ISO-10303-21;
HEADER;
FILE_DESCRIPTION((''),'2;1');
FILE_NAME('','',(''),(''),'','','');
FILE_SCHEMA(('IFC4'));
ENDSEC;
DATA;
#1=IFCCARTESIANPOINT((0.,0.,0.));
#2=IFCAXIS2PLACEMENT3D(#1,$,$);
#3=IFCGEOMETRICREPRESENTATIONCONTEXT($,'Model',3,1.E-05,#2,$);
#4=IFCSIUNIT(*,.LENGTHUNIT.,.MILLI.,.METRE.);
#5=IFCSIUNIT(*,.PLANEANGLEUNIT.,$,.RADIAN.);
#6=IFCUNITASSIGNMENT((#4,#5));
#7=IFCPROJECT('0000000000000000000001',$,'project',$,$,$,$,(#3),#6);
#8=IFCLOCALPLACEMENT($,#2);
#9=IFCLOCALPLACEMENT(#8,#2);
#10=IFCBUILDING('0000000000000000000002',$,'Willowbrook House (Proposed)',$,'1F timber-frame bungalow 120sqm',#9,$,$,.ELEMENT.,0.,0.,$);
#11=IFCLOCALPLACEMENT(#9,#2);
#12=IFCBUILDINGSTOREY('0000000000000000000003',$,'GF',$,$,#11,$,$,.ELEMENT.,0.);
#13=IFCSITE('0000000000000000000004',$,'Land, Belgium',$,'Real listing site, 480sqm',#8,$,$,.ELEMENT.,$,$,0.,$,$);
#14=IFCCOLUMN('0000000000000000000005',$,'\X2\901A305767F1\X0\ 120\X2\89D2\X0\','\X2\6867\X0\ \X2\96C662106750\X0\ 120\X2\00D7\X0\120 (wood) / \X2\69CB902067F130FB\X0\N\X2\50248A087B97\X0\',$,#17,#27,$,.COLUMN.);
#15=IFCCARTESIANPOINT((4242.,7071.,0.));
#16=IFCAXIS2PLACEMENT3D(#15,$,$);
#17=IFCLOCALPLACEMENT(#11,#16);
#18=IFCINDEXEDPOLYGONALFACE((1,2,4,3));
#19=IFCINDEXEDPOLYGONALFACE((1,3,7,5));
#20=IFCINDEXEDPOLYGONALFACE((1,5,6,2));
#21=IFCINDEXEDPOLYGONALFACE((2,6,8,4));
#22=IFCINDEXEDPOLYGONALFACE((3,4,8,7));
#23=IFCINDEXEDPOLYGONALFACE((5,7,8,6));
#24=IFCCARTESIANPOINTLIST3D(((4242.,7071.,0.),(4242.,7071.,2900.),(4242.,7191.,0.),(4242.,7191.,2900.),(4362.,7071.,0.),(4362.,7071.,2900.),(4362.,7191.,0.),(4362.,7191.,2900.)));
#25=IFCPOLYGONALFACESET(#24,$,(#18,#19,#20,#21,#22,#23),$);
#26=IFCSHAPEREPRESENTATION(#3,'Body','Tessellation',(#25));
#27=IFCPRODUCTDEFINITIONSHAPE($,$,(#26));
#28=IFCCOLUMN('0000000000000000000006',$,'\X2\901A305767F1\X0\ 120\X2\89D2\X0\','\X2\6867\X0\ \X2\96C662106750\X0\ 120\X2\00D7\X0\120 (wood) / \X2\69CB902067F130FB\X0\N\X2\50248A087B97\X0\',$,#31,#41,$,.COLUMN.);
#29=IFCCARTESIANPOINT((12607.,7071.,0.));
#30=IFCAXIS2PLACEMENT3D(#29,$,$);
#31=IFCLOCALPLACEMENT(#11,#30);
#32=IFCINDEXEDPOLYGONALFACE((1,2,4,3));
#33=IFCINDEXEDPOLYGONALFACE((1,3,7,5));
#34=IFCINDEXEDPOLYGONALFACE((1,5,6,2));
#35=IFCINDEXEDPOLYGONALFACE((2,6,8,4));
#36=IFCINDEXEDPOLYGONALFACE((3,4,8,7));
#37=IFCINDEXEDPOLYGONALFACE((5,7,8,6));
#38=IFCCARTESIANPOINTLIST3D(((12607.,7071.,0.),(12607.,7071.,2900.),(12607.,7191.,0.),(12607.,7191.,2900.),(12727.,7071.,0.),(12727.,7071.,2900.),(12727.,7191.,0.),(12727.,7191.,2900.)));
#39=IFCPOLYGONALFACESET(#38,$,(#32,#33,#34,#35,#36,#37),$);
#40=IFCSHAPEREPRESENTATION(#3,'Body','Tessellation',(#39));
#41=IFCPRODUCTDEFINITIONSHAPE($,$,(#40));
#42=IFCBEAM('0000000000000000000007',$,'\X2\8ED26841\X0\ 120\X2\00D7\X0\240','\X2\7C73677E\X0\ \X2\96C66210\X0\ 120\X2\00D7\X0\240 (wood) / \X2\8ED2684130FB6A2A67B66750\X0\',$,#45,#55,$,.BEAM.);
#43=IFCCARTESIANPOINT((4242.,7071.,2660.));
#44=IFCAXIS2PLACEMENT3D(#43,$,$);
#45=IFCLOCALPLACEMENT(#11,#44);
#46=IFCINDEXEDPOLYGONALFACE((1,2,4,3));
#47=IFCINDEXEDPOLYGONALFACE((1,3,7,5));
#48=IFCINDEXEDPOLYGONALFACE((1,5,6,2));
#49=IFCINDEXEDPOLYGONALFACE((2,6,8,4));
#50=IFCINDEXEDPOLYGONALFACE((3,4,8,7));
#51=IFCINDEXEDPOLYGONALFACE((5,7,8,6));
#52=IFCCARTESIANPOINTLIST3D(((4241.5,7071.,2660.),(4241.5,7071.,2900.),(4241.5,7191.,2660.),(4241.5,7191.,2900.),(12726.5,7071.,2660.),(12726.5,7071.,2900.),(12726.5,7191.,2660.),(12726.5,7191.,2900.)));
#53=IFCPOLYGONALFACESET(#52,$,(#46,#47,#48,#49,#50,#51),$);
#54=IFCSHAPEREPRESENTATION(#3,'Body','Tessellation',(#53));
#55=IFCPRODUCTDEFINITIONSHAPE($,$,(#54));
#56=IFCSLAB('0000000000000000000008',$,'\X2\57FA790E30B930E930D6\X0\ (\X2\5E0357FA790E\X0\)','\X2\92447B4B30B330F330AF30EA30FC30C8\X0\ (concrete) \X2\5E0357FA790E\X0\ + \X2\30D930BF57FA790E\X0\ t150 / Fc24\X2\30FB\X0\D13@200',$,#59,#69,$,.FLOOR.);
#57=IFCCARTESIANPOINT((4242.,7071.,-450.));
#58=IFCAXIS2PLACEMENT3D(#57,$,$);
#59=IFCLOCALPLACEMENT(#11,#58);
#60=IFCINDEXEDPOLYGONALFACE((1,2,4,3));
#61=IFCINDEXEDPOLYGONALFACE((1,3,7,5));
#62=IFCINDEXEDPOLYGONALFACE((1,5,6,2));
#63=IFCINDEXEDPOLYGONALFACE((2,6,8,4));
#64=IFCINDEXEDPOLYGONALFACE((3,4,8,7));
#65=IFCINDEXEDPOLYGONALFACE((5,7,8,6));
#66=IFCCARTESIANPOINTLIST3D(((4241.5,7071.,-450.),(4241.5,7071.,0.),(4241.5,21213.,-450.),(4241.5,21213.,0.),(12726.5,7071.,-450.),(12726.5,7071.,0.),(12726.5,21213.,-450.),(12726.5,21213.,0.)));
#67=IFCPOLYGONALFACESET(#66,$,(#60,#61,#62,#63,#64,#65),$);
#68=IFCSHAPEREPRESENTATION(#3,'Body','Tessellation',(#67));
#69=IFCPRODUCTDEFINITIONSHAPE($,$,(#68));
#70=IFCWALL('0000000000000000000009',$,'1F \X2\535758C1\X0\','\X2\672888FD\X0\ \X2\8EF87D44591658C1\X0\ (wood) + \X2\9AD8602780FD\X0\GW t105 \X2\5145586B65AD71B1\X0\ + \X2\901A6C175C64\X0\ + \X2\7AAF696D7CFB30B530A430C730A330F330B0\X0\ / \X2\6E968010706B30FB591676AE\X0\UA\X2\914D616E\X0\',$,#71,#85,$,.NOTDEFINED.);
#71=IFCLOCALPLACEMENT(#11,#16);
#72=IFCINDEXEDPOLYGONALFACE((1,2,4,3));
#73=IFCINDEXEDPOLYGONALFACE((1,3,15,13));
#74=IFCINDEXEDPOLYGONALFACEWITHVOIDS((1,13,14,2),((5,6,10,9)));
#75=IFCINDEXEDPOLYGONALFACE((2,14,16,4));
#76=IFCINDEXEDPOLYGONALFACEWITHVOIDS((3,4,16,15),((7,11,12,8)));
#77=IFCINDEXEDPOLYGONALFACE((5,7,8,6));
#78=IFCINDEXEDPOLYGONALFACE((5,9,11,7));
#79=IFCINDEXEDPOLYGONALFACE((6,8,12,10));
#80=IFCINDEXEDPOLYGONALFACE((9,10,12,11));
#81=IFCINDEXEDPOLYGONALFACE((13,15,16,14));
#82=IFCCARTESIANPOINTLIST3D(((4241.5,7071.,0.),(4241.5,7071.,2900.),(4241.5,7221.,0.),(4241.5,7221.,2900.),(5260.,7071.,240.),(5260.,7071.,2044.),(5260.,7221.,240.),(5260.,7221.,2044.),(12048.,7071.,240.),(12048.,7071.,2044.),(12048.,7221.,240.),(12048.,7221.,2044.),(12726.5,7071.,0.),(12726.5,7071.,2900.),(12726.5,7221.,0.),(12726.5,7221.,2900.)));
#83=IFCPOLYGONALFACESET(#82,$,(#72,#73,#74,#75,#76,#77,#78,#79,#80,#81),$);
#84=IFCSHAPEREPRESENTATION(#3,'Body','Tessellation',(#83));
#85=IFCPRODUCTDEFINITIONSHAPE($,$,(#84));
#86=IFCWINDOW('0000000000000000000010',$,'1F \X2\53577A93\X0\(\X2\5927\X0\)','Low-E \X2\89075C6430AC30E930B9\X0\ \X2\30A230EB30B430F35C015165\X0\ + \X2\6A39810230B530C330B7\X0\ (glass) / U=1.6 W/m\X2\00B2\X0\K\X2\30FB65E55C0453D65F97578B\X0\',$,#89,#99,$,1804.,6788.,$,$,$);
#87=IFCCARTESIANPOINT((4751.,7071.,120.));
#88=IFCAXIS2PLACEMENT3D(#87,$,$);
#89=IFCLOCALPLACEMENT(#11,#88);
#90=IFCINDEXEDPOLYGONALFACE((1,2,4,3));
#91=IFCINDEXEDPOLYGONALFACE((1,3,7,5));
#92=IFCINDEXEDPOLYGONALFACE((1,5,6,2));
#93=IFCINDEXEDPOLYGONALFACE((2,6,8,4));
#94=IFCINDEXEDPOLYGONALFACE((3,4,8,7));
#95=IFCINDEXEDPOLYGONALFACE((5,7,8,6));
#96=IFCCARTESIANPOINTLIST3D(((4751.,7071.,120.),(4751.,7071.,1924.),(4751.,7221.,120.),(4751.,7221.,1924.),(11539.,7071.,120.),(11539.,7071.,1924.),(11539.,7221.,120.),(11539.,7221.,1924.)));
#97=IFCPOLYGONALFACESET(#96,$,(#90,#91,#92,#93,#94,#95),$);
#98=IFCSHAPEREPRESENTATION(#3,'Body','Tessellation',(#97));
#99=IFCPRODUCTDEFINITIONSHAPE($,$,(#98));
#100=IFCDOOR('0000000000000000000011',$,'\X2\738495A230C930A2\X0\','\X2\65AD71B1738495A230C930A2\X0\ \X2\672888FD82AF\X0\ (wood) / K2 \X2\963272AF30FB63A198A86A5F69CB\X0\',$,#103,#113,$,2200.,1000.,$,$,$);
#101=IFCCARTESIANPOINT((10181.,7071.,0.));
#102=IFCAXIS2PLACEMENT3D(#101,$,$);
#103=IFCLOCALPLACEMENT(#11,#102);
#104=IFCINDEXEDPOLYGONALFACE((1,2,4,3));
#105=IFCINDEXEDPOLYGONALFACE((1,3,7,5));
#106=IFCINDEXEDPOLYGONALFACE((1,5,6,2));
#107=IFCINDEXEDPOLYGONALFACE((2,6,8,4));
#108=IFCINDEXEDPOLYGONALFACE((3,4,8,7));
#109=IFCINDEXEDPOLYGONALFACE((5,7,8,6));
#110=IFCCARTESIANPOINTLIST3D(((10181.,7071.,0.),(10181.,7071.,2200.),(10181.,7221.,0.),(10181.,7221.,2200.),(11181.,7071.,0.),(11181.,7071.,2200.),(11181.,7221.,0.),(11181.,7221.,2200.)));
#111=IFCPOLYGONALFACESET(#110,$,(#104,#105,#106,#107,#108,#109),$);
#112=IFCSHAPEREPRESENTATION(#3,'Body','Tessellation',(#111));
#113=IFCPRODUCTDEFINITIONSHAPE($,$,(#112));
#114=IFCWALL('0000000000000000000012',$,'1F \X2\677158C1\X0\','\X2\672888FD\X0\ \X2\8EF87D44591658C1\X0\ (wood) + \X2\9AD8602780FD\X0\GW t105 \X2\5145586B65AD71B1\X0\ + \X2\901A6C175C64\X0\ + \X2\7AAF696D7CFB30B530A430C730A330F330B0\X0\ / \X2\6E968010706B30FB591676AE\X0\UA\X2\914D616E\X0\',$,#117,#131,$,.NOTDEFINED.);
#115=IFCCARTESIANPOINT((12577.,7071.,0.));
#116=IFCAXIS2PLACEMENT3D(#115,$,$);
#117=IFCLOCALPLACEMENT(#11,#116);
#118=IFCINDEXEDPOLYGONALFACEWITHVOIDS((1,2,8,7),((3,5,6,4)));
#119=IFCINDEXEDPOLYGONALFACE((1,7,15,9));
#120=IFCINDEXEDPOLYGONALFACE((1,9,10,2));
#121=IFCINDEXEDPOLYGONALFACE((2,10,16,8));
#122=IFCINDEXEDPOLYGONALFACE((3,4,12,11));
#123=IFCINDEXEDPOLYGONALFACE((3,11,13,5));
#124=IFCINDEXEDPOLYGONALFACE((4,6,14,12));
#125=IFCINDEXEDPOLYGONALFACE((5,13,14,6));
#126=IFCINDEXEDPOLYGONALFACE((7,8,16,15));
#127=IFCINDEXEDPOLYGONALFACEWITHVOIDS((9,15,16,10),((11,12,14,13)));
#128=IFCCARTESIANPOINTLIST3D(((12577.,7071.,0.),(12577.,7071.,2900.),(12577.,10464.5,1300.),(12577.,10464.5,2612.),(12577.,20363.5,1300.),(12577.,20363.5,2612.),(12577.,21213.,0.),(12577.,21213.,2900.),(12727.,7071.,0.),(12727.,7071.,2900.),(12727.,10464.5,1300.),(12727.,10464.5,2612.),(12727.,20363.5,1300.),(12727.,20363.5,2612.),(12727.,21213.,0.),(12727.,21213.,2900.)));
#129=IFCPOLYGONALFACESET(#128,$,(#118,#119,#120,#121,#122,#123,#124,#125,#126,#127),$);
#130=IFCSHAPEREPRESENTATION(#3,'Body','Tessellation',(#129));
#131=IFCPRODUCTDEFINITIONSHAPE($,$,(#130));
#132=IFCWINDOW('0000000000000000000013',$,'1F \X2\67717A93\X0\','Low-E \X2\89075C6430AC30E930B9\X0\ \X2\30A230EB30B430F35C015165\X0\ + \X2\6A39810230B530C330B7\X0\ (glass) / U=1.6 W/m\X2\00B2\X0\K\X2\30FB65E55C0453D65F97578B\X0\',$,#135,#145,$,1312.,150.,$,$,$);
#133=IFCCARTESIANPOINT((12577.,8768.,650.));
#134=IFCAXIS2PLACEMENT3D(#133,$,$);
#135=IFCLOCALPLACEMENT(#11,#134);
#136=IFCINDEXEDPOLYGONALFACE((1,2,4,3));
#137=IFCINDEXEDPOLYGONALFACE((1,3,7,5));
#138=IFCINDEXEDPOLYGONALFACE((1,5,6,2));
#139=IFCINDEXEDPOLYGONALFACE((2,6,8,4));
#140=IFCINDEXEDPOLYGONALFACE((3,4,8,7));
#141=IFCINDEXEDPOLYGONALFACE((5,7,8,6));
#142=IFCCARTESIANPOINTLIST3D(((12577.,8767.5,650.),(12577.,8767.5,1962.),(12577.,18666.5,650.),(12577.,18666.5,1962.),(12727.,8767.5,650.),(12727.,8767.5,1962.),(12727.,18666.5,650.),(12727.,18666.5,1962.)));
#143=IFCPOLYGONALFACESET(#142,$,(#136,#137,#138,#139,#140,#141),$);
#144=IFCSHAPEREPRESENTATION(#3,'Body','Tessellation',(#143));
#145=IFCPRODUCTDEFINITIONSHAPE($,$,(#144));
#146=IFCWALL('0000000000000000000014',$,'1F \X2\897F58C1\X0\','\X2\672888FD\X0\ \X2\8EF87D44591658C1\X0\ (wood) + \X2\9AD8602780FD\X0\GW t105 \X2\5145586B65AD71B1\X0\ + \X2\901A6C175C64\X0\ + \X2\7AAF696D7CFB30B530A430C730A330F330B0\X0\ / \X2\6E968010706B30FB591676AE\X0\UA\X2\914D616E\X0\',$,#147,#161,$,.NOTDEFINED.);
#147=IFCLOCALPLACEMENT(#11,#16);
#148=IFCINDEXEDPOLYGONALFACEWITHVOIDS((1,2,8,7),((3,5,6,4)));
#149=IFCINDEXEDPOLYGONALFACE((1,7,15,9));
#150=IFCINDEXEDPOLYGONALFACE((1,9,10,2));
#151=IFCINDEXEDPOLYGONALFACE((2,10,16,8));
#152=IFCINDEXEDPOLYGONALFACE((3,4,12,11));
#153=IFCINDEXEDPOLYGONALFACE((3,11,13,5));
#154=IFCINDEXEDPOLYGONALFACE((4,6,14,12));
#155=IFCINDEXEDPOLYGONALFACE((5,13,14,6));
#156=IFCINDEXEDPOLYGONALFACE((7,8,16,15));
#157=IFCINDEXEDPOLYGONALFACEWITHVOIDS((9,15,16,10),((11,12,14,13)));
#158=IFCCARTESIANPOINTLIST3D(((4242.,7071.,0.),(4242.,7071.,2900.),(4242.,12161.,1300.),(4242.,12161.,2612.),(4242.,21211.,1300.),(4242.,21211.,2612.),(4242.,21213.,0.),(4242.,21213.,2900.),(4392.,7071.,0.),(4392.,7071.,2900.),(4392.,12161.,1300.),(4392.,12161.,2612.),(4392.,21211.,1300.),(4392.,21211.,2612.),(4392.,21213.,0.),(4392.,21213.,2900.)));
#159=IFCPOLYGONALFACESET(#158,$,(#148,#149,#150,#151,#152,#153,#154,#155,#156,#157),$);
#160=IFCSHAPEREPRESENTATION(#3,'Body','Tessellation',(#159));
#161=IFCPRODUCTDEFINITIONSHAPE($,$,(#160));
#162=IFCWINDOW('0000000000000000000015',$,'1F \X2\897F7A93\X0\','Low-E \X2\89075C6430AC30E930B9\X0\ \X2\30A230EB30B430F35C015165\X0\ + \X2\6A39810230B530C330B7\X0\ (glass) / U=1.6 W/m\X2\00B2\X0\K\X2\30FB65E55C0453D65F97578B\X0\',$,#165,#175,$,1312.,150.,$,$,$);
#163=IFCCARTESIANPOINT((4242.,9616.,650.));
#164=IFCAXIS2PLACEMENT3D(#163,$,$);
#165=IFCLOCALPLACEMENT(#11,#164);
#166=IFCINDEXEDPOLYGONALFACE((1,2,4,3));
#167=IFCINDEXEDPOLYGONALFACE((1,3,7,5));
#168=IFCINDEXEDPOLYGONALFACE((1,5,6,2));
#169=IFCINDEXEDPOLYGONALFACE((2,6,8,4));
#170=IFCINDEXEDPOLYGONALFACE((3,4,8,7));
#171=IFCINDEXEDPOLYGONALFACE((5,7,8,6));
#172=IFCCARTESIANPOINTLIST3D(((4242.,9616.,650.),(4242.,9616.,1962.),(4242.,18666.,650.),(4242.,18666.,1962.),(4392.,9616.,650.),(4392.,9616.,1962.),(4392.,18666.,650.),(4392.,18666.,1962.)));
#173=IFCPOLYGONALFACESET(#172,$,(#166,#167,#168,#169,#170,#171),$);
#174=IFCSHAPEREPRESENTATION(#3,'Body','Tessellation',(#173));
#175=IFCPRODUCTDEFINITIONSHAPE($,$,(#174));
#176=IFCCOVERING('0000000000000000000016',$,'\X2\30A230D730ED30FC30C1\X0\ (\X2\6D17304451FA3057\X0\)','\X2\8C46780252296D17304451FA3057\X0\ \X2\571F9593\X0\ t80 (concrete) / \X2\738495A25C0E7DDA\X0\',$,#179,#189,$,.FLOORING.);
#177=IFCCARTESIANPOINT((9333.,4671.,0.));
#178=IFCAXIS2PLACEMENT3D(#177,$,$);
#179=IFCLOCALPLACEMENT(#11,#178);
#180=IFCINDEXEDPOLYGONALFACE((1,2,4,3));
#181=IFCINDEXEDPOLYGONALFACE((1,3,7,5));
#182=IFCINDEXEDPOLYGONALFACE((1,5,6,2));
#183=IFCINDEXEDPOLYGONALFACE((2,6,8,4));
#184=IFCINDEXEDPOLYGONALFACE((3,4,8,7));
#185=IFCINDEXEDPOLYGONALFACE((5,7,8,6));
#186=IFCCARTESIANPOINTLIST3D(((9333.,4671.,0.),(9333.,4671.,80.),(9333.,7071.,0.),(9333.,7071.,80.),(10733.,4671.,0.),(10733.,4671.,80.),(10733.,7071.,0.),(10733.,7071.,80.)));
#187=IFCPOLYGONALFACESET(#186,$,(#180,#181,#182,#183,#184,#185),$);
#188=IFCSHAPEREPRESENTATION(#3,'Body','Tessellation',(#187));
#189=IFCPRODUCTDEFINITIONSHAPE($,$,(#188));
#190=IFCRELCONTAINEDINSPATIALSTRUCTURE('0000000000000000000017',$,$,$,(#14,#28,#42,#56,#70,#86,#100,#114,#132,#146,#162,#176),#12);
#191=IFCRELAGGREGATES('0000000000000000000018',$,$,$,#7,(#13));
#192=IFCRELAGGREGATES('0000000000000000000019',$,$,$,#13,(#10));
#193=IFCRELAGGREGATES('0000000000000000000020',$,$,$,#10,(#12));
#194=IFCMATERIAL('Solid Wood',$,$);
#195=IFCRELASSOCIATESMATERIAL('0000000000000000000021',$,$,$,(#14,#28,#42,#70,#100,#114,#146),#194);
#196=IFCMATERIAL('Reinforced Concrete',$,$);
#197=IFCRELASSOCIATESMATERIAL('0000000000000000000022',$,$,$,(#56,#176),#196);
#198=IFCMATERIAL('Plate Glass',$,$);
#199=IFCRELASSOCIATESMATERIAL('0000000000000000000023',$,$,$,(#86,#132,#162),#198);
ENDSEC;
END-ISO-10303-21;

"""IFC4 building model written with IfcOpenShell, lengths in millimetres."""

from ifc_helpers import new_model, si_unit, frame, frame_2d, origin, place, context, project, spatial, rectangle, extrude, material, element, fill, save


model = new_model("IFC4")

# Units and contexts
model_context = context("Model", 3, precision=1e-05, world=origin())
ifc_project = project(units=[si_unit("LENGTHUNIT", "METRE", prefix="MILLI"), si_unit("PLANEANGLEUNIT", "RADIAN")], contexts=[model_context])

# Site, building, storey
site_placement = place(None, origin())
site = spatial("IfcSite", under=ifc_project, at=site_placement, Name="Land, Belgium", ObjectType="Real listing site, 480sqm", CompositionType="ELEMENT", RefElevation=0.0)
building_placement = place(site_placement, origin())
building = spatial("IfcBuilding", under=site, at=building_placement, Name="Willowbrook House (Proposed)", ObjectType="1F timber-frame bungalow 120sqm", CompositionType="ELEMENT", ElevationOfRefHeight=0.0, ElevationOfTerrain=0.0)
storey_placement = place(building_placement, origin())
storey = spatial("IfcBuildingStorey", under=building, at=storey_placement, Name="GF", CompositionType="ELEMENT", Elevation=0.0)

# Columns
ifc_material_1 = material(Name="Solid Wood")
column_1_placement = place(storey_placement, frame((4242.0, 7071.0, 0.0)))
element("IfcColumn", 1, at=column_1_placement, inside=storey, material=ifc_material_1, Name="通し柱 120角", Description="桧 集成材 120×120 (wood) / 構造柱・N値計算", PredefinedType="COLUMN", context=model_context, shape_type="SweptSolid", body=[
    extrude(rectangle(XDim=120.0, YDim=120.0, at=frame_2d((60.0, 60.0))), frame((4242.0, 7071.0, 0.0)), (0.0, 0.0, 1.0), 2900.0),
])
column_2_placement = place(storey_placement, frame((12607.0, 7071.0, 0.0)))
element("IfcColumn", 2, at=column_2_placement, inside=storey, material=ifc_material_1, Name="通し柱 120角", Description="桧 集成材 120×120 (wood) / 構造柱・N値計算", PredefinedType="COLUMN", context=model_context, shape_type="SweptSolid", body=[
    extrude(rectangle(XDim=120.0, YDim=120.0, at=frame_2d((60.0, 60.0))), frame((12607.0, 7071.0, 0.0)), (0.0, 0.0, 1.0), 2900.0),
])

# Beam
beam_1_placement = place(storey_placement, frame((4242.0, 7071.0, 2660.0)))
element("IfcBeam", 3, at=beam_1_placement, inside=storey, material=ifc_material_1, Name="軒桁 120×240", Description="米松 集成 120×240 (wood) / 軒桁・横架材", PredefinedType="BEAM", context=model_context, shape_type="SweptSolid", body=[
    extrude(rectangle(XDim=8485.0, YDim=120.0, at=frame_2d((4242.0, 60.0))), frame((4242.0, 7071.0, 2660.0)), (0.0, 0.0, 1.0), 240.0),
])

# Slab
ifc_material_2 = material(Name="Reinforced Concrete")
slab_1_placement = place(storey_placement, frame((4242.0, 7071.0, -450.0)))
element("IfcSlab", 4, at=slab_1_placement, inside=storey, material=ifc_material_2, Name="基礎スラブ (布基礎)", Description="鉄筋コンクリート (concrete) 布基礎 + ベタ基礎 t150 / Fc24・D13@200", PredefinedType="FLOOR", context=model_context, shape_type="SweptSolid", body=[
    extrude(rectangle(XDim=8485.0, YDim=14142.0, at=frame_2d((4242.0, 7071.0))), frame((4242.0, 7071.0, -450.0)), (0.0, 0.0, 1.0), 450.0),
])

# Wall, openings, window, door
wall_1_placement = place(storey_placement, frame((4242.0, 7071.0, 0.0)))
wall_1 = element("IfcWall", 5, at=wall_1_placement, inside=storey, material=ifc_material_1, Name="1F 南壁", Description="木製 軸組外壁 (wood) + 高性能GW t105 充填断熱 + 通気層 + 窯業系サイディング / 準耐火・外皮UA配慮", PredefinedType="NOTDEFINED", context=model_context, shape_type="SweptSolid", body=[
    extrude(rectangle(XDim=8485.0, YDim=150.0, at=frame_2d((4242.0, 75.0))), frame((4242.0, 7071.0, 0.0)), (0.0, 0.0, 1.0), 2900.0),
])
opening_1_placement = place(storey_placement, frame((4751.0, 7071.0, 120.0)))
opening_1 = element("IfcOpeningElement", 6, at=opening_1_placement, cuts=wall_1, PredefinedType="NOTDEFINED", context=model_context, shape_type="SweptSolid", body=[
    extrude(rectangle(XDim=6788.0, YDim=150.0, at=frame_2d((3394.0, 75.0))), frame((4751.0, 7071.0, 120.0)), (0.0, 0.0, 1.0), 1804.0),
])
opening_2_placement = place(storey_placement, frame((10181.0, 7071.0, 0.0)))
opening_2 = element("IfcOpeningElement", 7, at=opening_2_placement, cuts=wall_1, PredefinedType="NOTDEFINED", context=model_context, shape_type="SweptSolid", body=[
    extrude(rectangle(XDim=1000.0, YDim=150.0, at=frame_2d((500.0, 75.0))), frame((10181.0, 7071.0, 0.0)), (0.0, 0.0, 1.0), 2200.0),
])
ifc_material_3 = material(Name="Plate Glass")
window_1_placement = place(storey_placement, frame((4751.0, 7071.0, 120.0)))
window_1 = element("IfcWindow", 8, at=window_1_placement, inside=storey, material=ifc_material_3, Name="1F 南窓(大)", Description="Low-E 複層ガラス アルゴン封入 + 樹脂サッシ (glass) / U=1.6 W/m²K・日射取得型", OverallHeight=1804.0, OverallWidth=6788.0, context=model_context, shape_type="SweptSolid", body=[
    extrude(rectangle(XDim=6788.0, YDim=150.0, at=frame_2d((3394.0, 75.0))), frame((4751.0, 7071.0, 120.0)), (0.0, 0.0, 1.0), 1804.0),
])
fill(opening_1, window_1)
door_placement = place(storey_placement, frame((10181.0, 7071.0, 0.0)))
door = element("IfcDoor", 9, at=door_placement, inside=storey, material=ifc_material_1, Name="玄関ドア", Description="断熱玄関ドア 木製芯 (wood) / K2 防犯・採風機構", OverallHeight=2200.0, OverallWidth=1000.0, context=model_context, shape_type="SweptSolid", body=[
    extrude(rectangle(XDim=1000.0, YDim=150.0, at=frame_2d((500.0, 75.0))), frame((10181.0, 7071.0, 0.0)), (0.0, 0.0, 1.0), 2200.0),
])
fill(opening_2, door)

# Walls, openings, windows
wall_2_placement = place(storey_placement, frame((12577.0, 7071.0, 0.0)))
wall_2 = element("IfcWall", 10, at=wall_2_placement, inside=storey, material=ifc_material_1, Name="1F 東壁", Description="木製 軸組外壁 (wood) + 高性能GW t105 充填断熱 + 通気層 + 窯業系サイディング / 準耐火・外皮UA配慮", PredefinedType="NOTDEFINED", context=model_context, shape_type="SweptSolid", body=[
    extrude(rectangle(XDim=150.0, YDim=14142.0, at=frame_2d((75.0, 7071.0))), frame((12577.0, 7071.0, 0.0)), (0.0, 0.0, 1.0), 2900.0),
])
opening_3_placement = place(storey_placement, frame((12577.0, 8768.0, 650.0)))
opening_3 = element("IfcOpeningElement", 11, at=opening_3_placement, cuts=wall_2, PredefinedType="NOTDEFINED", context=model_context, shape_type="SweptSolid", body=[
    extrude(rectangle(XDim=150.0, YDim=9899.0, at=frame_2d((75.0, 4949.0))), frame((12577.0, 8768.0, 650.0)), (0.0, 0.0, 1.0), 1312.0),
])
window_2_placement = place(storey_placement, frame((12577.0, 8768.0, 650.0)))
window_2 = element("IfcWindow", 12, at=window_2_placement, inside=storey, material=ifc_material_3, Name="1F 東窓", Description="Low-E 複層ガラス アルゴン封入 + 樹脂サッシ (glass) / U=1.6 W/m²K・日射取得型", OverallHeight=1312.0, OverallWidth=150.0, context=model_context, shape_type="SweptSolid", body=[
    extrude(rectangle(XDim=150.0, YDim=9899.0, at=frame_2d((75.0, 4949.0))), frame((12577.0, 8768.0, 650.0)), (0.0, 0.0, 1.0), 1312.0),
])
fill(opening_3, window_2)
wall_3_placement = place(storey_placement, frame((4242.0, 7071.0, 0.0)))
wall_3 = element("IfcWall", 13, at=wall_3_placement, inside=storey, material=ifc_material_1, Name="1F 西壁", Description="木製 軸組外壁 (wood) + 高性能GW t105 充填断熱 + 通気層 + 窯業系サイディング / 準耐火・外皮UA配慮", PredefinedType="NOTDEFINED", context=model_context, shape_type="SweptSolid", body=[
    extrude(rectangle(XDim=150.0, YDim=14142.0, at=frame_2d((75.0, 7071.0))), frame((4242.0, 7071.0, 0.0)), (0.0, 0.0, 1.0), 2900.0),
])
opening_4_placement = place(storey_placement, frame((4242.0, 9616.0, 650.0)))
opening_4 = element("IfcOpeningElement", 14, at=opening_4_placement, cuts=wall_3, PredefinedType="NOTDEFINED", context=model_context, shape_type="SweptSolid", body=[
    extrude(rectangle(XDim=150.0, YDim=9050.0, at=frame_2d((75.0, 4525.0))), frame((4242.0, 9616.0, 650.0)), (0.0, 0.0, 1.0), 1312.0),
])
window_3_placement = place(storey_placement, frame((4242.0, 9616.0, 650.0)))
window_3 = element("IfcWindow", 15, at=window_3_placement, inside=storey, material=ifc_material_3, Name="1F 西窓", Description="Low-E 複層ガラス アルゴン封入 + 樹脂サッシ (glass) / U=1.6 W/m²K・日射取得型", OverallHeight=1312.0, OverallWidth=150.0, context=model_context, shape_type="SweptSolid", body=[
    extrude(rectangle(XDim=150.0, YDim=9050.0, at=frame_2d((75.0, 4525.0))), frame((4242.0, 9616.0, 650.0)), (0.0, 0.0, 1.0), 1312.0),
])
fill(opening_4, window_3)

# Covering
covering_1_placement = place(storey_placement, frame((9333.0, 4671.0, 0.0)))
element("IfcCovering", 16, at=covering_1_placement, inside=storey, material=ifc_material_2, Name="アプローチ (洗い出し)", Description="豆砂利洗い出し 土間 t80 (concrete) / 玄関導線", PredefinedType="FLOORING", context=model_context, shape_type="SweptSolid", body=[
    extrude(rectangle(XDim=1400.0, YDim=2400.0, at=frame_2d((700.0, 1200.0))), frame((9333.0, 4671.0, 0.0)), (0.0, 0.0, 1.0), 80.0),
])

save(model, "model.ifc")
